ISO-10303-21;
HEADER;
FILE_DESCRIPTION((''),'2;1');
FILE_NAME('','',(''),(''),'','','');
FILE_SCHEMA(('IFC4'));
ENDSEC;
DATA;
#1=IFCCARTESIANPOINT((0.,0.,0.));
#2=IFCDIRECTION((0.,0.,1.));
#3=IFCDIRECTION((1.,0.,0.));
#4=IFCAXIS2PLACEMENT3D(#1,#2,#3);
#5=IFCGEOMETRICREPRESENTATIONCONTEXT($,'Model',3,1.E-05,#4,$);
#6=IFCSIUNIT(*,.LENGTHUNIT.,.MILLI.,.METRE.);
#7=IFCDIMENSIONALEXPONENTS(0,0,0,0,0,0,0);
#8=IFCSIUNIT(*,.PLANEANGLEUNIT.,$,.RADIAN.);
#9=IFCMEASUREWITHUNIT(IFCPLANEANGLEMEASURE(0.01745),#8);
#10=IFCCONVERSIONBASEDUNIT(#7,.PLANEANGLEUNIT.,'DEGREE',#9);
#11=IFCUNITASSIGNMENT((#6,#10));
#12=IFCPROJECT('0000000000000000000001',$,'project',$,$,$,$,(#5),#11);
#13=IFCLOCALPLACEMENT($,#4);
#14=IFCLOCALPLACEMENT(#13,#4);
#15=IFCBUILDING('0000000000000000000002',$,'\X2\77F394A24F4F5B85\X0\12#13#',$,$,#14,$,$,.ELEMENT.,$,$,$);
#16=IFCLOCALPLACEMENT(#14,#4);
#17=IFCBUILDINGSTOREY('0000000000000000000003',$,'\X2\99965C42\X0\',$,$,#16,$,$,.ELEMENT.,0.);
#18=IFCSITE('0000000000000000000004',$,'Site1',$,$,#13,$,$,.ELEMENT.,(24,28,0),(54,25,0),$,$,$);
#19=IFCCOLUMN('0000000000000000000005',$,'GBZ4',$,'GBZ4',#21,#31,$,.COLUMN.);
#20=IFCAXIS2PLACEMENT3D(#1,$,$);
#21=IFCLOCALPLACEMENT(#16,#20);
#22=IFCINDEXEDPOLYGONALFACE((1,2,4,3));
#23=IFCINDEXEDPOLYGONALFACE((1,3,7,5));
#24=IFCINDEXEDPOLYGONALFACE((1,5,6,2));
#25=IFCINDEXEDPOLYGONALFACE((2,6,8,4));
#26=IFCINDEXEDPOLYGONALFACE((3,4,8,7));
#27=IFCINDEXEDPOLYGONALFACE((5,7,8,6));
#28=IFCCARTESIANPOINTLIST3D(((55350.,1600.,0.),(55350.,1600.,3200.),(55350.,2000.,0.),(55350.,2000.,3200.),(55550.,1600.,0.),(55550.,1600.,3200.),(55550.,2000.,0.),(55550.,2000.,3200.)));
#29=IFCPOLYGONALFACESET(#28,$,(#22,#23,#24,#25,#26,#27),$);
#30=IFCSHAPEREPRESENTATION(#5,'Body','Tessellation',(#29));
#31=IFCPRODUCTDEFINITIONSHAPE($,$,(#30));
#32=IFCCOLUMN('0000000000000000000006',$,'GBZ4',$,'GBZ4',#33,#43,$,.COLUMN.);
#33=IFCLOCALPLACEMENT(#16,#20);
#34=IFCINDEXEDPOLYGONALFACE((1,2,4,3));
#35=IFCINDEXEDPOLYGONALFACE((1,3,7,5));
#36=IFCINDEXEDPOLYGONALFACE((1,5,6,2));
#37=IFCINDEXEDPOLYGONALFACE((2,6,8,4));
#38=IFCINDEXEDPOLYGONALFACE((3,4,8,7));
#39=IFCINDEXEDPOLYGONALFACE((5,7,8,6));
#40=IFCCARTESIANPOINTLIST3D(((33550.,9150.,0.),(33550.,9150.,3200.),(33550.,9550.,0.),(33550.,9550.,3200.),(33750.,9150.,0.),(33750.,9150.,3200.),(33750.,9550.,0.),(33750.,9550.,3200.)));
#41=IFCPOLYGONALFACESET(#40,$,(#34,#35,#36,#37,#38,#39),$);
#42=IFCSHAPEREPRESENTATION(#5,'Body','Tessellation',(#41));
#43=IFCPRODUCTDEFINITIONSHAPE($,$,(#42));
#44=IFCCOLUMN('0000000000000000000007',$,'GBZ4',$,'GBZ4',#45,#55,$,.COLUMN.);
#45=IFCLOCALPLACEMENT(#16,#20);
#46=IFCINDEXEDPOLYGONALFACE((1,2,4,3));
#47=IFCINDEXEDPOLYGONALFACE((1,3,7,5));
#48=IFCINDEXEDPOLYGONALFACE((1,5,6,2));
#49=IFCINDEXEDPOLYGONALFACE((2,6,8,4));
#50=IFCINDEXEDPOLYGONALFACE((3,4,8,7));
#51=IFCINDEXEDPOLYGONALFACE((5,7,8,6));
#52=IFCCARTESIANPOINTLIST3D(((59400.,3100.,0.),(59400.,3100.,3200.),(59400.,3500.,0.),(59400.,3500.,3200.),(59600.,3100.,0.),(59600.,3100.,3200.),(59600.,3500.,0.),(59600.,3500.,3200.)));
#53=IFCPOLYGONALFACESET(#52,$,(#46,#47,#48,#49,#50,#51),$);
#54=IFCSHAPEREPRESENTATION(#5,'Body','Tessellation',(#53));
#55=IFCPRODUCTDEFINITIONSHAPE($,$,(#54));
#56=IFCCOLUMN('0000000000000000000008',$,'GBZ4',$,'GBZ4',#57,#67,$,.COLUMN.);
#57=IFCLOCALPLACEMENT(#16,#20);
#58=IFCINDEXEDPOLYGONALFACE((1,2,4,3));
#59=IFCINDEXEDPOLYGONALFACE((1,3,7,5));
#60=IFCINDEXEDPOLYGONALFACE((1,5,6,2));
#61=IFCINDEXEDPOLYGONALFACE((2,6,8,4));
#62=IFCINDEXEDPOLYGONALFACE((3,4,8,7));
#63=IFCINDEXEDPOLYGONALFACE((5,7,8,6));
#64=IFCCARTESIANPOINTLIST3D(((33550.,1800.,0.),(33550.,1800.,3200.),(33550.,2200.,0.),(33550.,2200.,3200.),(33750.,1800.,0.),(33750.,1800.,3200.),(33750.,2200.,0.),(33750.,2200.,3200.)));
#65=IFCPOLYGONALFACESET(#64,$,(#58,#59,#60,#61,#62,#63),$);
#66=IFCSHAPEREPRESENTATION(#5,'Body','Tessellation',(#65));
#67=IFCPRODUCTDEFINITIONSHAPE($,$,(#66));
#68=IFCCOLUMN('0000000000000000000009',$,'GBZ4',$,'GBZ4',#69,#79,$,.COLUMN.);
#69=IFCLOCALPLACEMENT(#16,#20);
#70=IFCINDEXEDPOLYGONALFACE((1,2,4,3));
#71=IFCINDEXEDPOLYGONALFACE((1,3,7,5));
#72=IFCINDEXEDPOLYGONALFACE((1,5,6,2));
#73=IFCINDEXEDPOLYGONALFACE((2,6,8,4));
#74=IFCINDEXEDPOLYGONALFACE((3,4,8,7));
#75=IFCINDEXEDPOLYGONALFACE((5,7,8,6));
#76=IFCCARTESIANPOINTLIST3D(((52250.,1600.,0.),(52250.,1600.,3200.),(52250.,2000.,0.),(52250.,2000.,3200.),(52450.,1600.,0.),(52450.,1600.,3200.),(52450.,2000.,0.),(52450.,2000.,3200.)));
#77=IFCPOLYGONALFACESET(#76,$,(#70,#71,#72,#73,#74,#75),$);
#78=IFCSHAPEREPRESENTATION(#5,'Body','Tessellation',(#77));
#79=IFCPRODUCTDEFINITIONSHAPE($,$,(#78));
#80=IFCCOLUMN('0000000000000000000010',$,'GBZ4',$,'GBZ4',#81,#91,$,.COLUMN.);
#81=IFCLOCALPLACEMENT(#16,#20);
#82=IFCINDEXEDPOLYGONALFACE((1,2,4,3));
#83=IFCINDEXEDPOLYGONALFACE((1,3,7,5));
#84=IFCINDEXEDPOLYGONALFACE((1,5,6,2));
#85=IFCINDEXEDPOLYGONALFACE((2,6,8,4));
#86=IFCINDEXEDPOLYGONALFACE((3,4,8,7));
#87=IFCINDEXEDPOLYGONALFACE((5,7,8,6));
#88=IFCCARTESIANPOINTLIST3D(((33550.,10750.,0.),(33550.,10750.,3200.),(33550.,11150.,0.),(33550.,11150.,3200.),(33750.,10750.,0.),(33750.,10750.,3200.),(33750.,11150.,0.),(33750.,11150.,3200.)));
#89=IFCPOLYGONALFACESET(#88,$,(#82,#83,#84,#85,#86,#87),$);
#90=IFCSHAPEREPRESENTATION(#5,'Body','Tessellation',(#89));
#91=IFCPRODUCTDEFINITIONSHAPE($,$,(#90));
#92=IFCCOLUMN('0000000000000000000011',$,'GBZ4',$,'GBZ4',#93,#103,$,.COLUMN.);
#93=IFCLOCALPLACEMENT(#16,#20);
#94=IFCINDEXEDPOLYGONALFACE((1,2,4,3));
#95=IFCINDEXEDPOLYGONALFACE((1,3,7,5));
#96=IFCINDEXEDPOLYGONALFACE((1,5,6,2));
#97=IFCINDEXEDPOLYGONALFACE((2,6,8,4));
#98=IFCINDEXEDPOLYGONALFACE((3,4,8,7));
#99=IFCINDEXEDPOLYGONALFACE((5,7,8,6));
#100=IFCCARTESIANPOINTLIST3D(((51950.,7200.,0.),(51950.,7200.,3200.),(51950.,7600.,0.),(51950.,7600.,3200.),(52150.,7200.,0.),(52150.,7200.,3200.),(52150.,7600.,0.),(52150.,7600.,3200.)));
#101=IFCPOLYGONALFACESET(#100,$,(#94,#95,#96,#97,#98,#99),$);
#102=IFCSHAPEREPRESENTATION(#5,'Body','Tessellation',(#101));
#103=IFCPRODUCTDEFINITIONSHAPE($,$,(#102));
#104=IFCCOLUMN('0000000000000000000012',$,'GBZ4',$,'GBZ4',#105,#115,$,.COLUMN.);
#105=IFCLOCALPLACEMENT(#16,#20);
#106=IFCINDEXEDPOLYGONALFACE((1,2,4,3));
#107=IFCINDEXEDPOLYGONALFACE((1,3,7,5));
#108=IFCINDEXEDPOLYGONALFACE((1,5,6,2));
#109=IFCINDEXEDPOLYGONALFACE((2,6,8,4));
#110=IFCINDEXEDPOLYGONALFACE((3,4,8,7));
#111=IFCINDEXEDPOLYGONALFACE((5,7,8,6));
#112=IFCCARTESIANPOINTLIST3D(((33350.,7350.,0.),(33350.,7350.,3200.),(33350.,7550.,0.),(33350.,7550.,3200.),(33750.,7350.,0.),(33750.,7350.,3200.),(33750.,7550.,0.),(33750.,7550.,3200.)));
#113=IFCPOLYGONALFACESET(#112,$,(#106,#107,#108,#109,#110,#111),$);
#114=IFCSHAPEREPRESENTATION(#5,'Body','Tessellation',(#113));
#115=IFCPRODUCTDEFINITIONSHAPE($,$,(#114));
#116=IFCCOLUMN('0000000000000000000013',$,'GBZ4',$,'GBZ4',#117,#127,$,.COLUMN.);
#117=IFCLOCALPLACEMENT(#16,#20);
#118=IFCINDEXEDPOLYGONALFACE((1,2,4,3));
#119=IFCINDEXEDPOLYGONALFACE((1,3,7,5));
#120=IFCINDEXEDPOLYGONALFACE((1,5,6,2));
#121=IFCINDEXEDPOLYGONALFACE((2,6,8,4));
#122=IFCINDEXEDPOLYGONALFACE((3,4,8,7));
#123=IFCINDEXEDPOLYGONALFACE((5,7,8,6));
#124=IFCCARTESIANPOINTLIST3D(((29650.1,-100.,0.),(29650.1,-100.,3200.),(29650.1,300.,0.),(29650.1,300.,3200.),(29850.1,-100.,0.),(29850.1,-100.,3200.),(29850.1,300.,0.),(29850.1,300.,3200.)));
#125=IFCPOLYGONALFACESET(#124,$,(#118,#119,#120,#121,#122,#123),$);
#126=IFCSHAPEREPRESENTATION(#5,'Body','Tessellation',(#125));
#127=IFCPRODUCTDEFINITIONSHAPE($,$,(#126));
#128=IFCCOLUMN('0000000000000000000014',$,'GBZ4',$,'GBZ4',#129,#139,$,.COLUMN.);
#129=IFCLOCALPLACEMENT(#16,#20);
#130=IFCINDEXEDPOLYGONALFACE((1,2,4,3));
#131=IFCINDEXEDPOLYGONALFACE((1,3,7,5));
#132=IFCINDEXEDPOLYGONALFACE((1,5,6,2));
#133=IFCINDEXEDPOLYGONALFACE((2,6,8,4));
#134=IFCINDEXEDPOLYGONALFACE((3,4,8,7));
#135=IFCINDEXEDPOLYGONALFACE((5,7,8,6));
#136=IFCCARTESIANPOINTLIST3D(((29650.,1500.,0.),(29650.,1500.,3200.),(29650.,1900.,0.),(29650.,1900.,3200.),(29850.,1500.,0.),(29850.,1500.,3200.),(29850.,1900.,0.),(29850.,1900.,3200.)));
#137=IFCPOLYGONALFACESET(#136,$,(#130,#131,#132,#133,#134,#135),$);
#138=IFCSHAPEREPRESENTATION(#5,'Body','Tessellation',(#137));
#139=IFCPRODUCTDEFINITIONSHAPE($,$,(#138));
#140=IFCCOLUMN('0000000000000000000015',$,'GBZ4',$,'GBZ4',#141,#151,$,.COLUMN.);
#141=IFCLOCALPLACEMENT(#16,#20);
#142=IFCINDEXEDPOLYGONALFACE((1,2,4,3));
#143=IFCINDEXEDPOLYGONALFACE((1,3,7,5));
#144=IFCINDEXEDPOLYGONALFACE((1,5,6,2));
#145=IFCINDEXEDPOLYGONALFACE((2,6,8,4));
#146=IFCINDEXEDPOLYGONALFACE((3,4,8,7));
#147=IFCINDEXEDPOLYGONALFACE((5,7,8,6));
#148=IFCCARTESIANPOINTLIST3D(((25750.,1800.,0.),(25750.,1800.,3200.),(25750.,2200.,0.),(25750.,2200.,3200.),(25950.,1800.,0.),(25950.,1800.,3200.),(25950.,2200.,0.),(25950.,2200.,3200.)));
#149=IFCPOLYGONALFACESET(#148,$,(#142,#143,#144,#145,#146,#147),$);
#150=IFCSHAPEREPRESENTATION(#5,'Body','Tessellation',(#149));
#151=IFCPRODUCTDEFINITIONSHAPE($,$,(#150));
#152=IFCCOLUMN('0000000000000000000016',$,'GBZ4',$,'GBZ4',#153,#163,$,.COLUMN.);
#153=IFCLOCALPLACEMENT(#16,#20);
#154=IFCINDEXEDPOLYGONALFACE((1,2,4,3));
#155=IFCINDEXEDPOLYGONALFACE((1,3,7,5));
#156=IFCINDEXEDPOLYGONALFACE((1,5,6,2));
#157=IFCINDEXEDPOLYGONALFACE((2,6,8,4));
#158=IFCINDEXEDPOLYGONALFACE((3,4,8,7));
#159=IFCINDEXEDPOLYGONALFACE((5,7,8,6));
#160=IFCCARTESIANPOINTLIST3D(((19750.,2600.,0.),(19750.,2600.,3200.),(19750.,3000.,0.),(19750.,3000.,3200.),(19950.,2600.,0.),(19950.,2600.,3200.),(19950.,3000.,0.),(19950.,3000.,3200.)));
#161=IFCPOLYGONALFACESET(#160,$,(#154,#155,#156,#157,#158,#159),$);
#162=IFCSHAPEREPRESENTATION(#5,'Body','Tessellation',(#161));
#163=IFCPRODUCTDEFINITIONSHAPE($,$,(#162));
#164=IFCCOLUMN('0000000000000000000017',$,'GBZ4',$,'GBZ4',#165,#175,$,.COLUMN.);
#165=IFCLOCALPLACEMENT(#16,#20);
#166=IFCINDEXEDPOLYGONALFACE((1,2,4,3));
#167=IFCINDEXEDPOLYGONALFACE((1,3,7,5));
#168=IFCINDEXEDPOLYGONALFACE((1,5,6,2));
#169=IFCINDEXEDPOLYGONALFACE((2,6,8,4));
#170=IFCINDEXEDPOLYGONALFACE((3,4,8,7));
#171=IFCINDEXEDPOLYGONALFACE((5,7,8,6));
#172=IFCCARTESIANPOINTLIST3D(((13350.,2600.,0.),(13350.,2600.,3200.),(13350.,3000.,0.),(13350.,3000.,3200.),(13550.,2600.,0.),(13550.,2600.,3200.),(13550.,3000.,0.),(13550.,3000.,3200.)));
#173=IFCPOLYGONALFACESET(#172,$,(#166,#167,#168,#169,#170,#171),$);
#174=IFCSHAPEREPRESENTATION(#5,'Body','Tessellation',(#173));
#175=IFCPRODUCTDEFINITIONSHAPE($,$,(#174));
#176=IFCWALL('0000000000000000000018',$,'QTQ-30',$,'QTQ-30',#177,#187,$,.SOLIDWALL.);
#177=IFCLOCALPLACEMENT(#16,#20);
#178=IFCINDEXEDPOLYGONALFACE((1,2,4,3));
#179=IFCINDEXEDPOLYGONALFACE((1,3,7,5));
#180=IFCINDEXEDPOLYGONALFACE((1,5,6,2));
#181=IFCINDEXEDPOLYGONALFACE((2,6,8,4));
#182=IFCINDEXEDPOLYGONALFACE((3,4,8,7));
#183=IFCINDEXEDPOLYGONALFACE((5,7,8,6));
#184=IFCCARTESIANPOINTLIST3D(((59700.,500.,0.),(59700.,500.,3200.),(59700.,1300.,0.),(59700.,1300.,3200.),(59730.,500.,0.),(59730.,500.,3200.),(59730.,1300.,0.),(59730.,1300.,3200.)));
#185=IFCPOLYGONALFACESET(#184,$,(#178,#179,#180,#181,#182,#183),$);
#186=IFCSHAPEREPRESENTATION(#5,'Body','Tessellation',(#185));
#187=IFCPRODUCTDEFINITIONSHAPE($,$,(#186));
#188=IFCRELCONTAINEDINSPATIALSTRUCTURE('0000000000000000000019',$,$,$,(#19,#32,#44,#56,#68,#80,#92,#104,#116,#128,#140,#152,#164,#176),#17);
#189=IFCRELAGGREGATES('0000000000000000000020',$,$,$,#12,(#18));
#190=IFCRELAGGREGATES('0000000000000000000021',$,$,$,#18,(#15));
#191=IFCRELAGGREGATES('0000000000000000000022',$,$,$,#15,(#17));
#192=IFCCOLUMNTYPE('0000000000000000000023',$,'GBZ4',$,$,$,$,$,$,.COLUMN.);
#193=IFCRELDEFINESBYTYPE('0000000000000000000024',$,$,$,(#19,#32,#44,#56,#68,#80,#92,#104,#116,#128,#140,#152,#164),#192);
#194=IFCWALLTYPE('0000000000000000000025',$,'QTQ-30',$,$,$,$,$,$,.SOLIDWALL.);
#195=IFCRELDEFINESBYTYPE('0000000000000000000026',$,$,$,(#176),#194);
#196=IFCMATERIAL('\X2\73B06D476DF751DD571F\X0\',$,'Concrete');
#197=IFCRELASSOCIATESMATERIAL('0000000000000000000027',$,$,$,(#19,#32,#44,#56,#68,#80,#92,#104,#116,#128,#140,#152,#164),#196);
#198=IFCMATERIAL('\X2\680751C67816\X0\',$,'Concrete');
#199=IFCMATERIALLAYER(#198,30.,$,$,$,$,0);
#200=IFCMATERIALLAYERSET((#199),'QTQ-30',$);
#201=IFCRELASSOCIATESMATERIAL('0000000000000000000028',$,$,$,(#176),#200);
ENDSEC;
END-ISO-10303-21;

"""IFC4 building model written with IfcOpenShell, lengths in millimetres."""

from ifc_helpers import new_model, entity, si_unit, converted_unit, frame, origin_with_axes, place, context, project, spatial, polyline, outline, extrude, material, layer, layer_set, type_object, element, save


model = new_model("IFC4")

# Units and contexts
model_context = context("Model", 3, precision=1e-05, world=origin_with_axes())
ifc_project = project(units=[si_unit("LENGTHUNIT", "METRE", prefix="MILLI"), converted_unit("PLANEANGLEUNIT", "DEGREE", entity("IfcPlaneAngleMeasure", 0.01745), si_unit("PLANEANGLEUNIT", "RADIAN"), dimensions=[0, 0, 0, 0, 0, 0, 0])], contexts=[model_context])

# Site, building, storey
site_placement = place(None, origin_with_axes())
site = spatial("IfcSite", under=ifc_project, at=site_placement, Name="Site1", CompositionType="ELEMENT", RefLatitude=(24, 28, 0), RefLongitude=(54, 25, 0))
building_placement = place(site_placement, origin_with_axes())
building = spatial("IfcBuilding", under=site, at=building_placement, Name="石钢住宅12#13#", CompositionType="ELEMENT")
storey_placement = place(building_placement, origin_with_axes())
storey = spatial("IfcBuildingStorey", under=building, at=storey_placement, Name="首层", CompositionType="ELEMENT", Elevation=0.0)

# Columns
ifc_material_1 = material(Name="现浇混凝土", Category="Concrete")
column_type_1 = type_object("IfcColumnType", Name="GBZ4", PredefinedType="COLUMN")
column_1_placement = place(storey_placement, origin_with_axes())
element("IfcColumn", 1, at=column_1_placement, inside=storey, type_object=column_type_1, material=ifc_material_1, Name="GBZ4", ObjectType="GBZ4", PredefinedType="COLUMN", context=model_context, shape_type="SweptSolid", body=[
    extrude(outline(polyline([(0.0, 0.0), (400.0, 0.0), (400.0, 200.0), (0.0, 200.0), (0.0, 0.0)])), frame((55550.0, 1600.0, 0.0), z_axis=(0.0, 0.0, 1.0), x_axis=(0.0, 1.0, 0.0)), (0.0, 0.0, 1.0), 3200.0),
])
column_2_placement = place(storey_placement, origin_with_axes())
element("IfcColumn", 2, at=column_2_placement, inside=storey, type_object=column_type_1, material=ifc_material_1, Name="GBZ4", ObjectType="GBZ4", PredefinedType="COLUMN", context=model_context, shape_type="SweptSolid", body=[
    extrude(outline(polyline([(0.0, 0.0), (400.0, 0.0), (400.0, 200.0), (0.0, 200.0), (0.0, 0.0)])), frame((33750.0, 9150.0, 0.0), z_axis=(0.0, 0.0, 1.0), x_axis=(0.0, 1.0, 0.0)), (0.0, 0.0, 1.0), 3200.0),
])
column_3_placement = place(storey_placement, origin_with_axes())
element("IfcColumn", 3, at=column_3_placement, inside=storey, type_object=column_type_1, material=ifc_material_1, Name="GBZ4", ObjectType="GBZ4", PredefinedType="COLUMN", context=model_context, shape_type="SweptSolid", body=[
    extrude(outline(polyline([(0.0, 0.0), (400.0, 0.0), (400.0, 200.0), (0.0, 200.0), (0.0, 0.0)])), frame((59600.0, 3100.0, 0.0), z_axis=(0.0, 0.0, 1.0), x_axis=(0.0, 1.0, 0.0)), (0.0, 0.0, 1.0), 3200.0),
])
column_4_placement = place(storey_placement, origin_with_axes())
element("IfcColumn", 4, at=column_4_placement, inside=storey, type_object=column_type_1, material=ifc_material_1, Name="GBZ4", ObjectType="GBZ4", PredefinedType="COLUMN", context=model_context, shape_type="SweptSolid", body=[
    extrude(outline(polyline([(0.0, 0.0), (400.0, 0.0), (400.0, 200.0), (0.0, 200.0), (0.0, 0.0)])), frame((33750.0, 1800.0, 0.0), z_axis=(0.0, 0.0, 1.0), x_axis=(0.0, 1.0, 0.0)), (0.0, 0.0, 1.0), 3200.0),
])
column_5_placement = place(storey_placement, origin_with_axes())
element("IfcColumn", 5, at=column_5_placement, inside=storey, type_object=column_type_1, material=ifc_material_1, Name="GBZ4", ObjectType="GBZ4", PredefinedType="COLUMN", context=model_context, shape_type="SweptSolid", body=[
    extrude(outline(polyline([(0.0, 0.0), (400.0, 0.0), (400.0, 200.0), (0.0, 200.0), (0.0, 0.0)])), frame((52450.0, 1600.0, 0.0), z_axis=(0.0, 0.0, 1.0), x_axis=(0.0, 1.0, 0.0)), (0.0, 0.0, 1.0), 3200.0),
])
column_6_placement = place(storey_placement, origin_with_axes())
element("IfcColumn", 6, at=column_6_placement, inside=storey, type_object=column_type_1, material=ifc_material_1, Name="GBZ4", ObjectType="GBZ4", PredefinedType="COLUMN", context=model_context, shape_type="SweptSolid", body=[
    extrude(outline(polyline([(0.0, 0.0), (400.0, 0.0), (400.0, 200.0), (0.0, 200.0), (0.0, 0.0)])), frame((33750.0, 10750.0, 0.0), z_axis=(0.0, 0.0, 1.0), x_axis=(0.0, 1.0, 0.0)), (0.0, 0.0, 1.0), 3200.0),
])
column_7_placement = place(storey_placement, origin_with_axes())
element("IfcColumn", 7, at=column_7_placement, inside=storey, type_object=column_type_1, material=ifc_material_1, Name="GBZ4", ObjectType="GBZ4", PredefinedType="COLUMN", context=model_context, shape_type="SweptSolid", body=[
    extrude(outline(polyline([(0.0, 0.0), (400.0, 0.0), (400.0, 200.0), (0.0, 200.0), (0.0, 0.0)])), frame((52150.0, 7200.0, 0.0), z_axis=(0.0, 0.0, 1.0), x_axis=(0.0, 1.0, 0.0)), (0.0, 0.0, 1.0), 3200.0),
])
column_8_placement = place(storey_placement, origin_with_axes())
element("IfcColumn", 8, at=column_8_placement, inside=storey, type_object=column_type_1, material=ifc_material_1, Name="GBZ4", ObjectType="GBZ4", PredefinedType="COLUMN", context=model_context, shape_type="SweptSolid", body=[
    extrude(outline(polyline([(0.0, 0.0), (400.0, 0.0), (400.0, 200.0), (0.0, 200.0), (0.0, 0.0)])), frame((33350.0, 7350.0, 0.0), z_axis=(0.0, 0.0, 1.0), x_axis=(1.0, 0.0, 0.0)), (0.0, 0.0, 1.0), 3200.0),
])
column_9_placement = place(storey_placement, origin_with_axes())
element("IfcColumn", 9, at=column_9_placement, inside=storey, type_object=column_type_1, material=ifc_material_1, Name="GBZ4", ObjectType="GBZ4", PredefinedType="COLUMN", context=model_context, shape_type="SweptSolid", body=[
    extrude(outline(polyline([(0.0, 0.0), (200.0, 0.0), (200.0, 400.0), (0.0, 400.0), (0.0, 0.0)])), frame((29650.1, -100.0, 0.0), z_axis=(0.0, 0.0, 1.0), x_axis=(1.0, 0.0, 0.0)), (0.0, 0.0, 1.0), 3200.0),
])
column_10_placement = place(storey_placement, origin_with_axes())
element("IfcColumn", 10, at=column_10_placement, inside=storey, type_object=column_type_1, material=ifc_material_1, Name="GBZ4", ObjectType="GBZ4", PredefinedType="COLUMN", context=model_context, shape_type="SweptSolid", body=[
    extrude(outline(polyline([(0.0, 0.0), (200.0, 0.0), (200.0, 400.0), (0.0, 400.0), (0.0, 0.0)])), frame((29650.0, 1500.0, 0.0), z_axis=(0.0, 0.0, 1.0), x_axis=(1.0, 0.0, 0.0)), (0.0, 0.0, 1.0), 3200.0),
])
column_11_placement = place(storey_placement, origin_with_axes())
element("IfcColumn", 11, at=column_11_placement, inside=storey, type_object=column_type_1, material=ifc_material_1, Name="GBZ4", ObjectType="GBZ4", PredefinedType="COLUMN", context=model_context, shape_type="SweptSolid", body=[
    extrude(outline(polyline([(0.0, 0.0), (200.0, 0.0), (200.0, 400.0), (0.0, 400.0), (0.0, 0.0)])), frame((25750.0, 1800.0, 0.0), z_axis=(0.0, 0.0, 1.0), x_axis=(1.0, 0.0, 0.0)), (0.0, 0.0, 1.0), 3200.0),
])
column_12_placement = place(storey_placement, origin_with_axes())
element("IfcColumn", 12, at=column_12_placement, inside=storey, type_object=column_type_1, material=ifc_material_1, Name="GBZ4", ObjectType="GBZ4", PredefinedType="COLUMN", context=model_context, shape_type="SweptSolid", body=[
    extrude(outline(polyline([(0.0, 0.0), (200.0, 0.0), (200.0, 400.0), (0.0, 400.0), (0.0, 0.0)])), frame((19750.0, 2600.0, 0.0), z_axis=(0.0, 0.0, 1.0), x_axis=(1.0, 0.0, 0.0)), (0.0, 0.0, 1.0), 3200.0),
])
column_13_placement = place(storey_placement, origin_with_axes())
element("IfcColumn", 13, at=column_13_placement, inside=storey, type_object=column_type_1, material=ifc_material_1, Name="GBZ4", ObjectType="GBZ4", PredefinedType="COLUMN", context=model_context, shape_type="SweptSolid", body=[
    extrude(outline(polyline([(0.0, 0.0), (200.0, 0.0), (200.0, 400.0), (0.0, 400.0), (0.0, 0.0)])), frame((13350.0, 2600.0, 0.0), z_axis=(0.0, 0.0, 1.0), x_axis=(1.0, 0.0, 0.0)), (0.0, 0.0, 1.0), 3200.0),
])

# Wall
ifc_material_2 = material(Name="标准砖", Category="Concrete")
ifc_layer = layer(ifc_material_2, 30.0, Priority=0)
ifc_layer_set = layer_set([ifc_layer], Name="QTQ-30")
wall_type = type_object("IfcWallType", Name="QTQ-30", PredefinedType="SOLIDWALL")
wall_1_placement = place(storey_placement, origin_with_axes())
element("IfcWall", 14, at=wall_1_placement, inside=storey, type_object=wall_type, material=ifc_layer_set, Name="QTQ-30", ObjectType="QTQ-30", PredefinedType="SOLIDWALL", context=model_context, shape_type="SweptSolid", body=[
    extrude(outline(polyline([(0.0, 0.0), (3200.0, 0.0), (3200.0, 800.0), (0.0, 800.0), (0.0, 0.0)])), frame((59730.0, 1300.0, 3200.0), z_axis=(-1.0, 0.0, 0.0), x_axis=(0.0, 0.0, -1.0)), (0.0, 0.0, 1.0), 30.0),
])

save(model, "model.ifc")
